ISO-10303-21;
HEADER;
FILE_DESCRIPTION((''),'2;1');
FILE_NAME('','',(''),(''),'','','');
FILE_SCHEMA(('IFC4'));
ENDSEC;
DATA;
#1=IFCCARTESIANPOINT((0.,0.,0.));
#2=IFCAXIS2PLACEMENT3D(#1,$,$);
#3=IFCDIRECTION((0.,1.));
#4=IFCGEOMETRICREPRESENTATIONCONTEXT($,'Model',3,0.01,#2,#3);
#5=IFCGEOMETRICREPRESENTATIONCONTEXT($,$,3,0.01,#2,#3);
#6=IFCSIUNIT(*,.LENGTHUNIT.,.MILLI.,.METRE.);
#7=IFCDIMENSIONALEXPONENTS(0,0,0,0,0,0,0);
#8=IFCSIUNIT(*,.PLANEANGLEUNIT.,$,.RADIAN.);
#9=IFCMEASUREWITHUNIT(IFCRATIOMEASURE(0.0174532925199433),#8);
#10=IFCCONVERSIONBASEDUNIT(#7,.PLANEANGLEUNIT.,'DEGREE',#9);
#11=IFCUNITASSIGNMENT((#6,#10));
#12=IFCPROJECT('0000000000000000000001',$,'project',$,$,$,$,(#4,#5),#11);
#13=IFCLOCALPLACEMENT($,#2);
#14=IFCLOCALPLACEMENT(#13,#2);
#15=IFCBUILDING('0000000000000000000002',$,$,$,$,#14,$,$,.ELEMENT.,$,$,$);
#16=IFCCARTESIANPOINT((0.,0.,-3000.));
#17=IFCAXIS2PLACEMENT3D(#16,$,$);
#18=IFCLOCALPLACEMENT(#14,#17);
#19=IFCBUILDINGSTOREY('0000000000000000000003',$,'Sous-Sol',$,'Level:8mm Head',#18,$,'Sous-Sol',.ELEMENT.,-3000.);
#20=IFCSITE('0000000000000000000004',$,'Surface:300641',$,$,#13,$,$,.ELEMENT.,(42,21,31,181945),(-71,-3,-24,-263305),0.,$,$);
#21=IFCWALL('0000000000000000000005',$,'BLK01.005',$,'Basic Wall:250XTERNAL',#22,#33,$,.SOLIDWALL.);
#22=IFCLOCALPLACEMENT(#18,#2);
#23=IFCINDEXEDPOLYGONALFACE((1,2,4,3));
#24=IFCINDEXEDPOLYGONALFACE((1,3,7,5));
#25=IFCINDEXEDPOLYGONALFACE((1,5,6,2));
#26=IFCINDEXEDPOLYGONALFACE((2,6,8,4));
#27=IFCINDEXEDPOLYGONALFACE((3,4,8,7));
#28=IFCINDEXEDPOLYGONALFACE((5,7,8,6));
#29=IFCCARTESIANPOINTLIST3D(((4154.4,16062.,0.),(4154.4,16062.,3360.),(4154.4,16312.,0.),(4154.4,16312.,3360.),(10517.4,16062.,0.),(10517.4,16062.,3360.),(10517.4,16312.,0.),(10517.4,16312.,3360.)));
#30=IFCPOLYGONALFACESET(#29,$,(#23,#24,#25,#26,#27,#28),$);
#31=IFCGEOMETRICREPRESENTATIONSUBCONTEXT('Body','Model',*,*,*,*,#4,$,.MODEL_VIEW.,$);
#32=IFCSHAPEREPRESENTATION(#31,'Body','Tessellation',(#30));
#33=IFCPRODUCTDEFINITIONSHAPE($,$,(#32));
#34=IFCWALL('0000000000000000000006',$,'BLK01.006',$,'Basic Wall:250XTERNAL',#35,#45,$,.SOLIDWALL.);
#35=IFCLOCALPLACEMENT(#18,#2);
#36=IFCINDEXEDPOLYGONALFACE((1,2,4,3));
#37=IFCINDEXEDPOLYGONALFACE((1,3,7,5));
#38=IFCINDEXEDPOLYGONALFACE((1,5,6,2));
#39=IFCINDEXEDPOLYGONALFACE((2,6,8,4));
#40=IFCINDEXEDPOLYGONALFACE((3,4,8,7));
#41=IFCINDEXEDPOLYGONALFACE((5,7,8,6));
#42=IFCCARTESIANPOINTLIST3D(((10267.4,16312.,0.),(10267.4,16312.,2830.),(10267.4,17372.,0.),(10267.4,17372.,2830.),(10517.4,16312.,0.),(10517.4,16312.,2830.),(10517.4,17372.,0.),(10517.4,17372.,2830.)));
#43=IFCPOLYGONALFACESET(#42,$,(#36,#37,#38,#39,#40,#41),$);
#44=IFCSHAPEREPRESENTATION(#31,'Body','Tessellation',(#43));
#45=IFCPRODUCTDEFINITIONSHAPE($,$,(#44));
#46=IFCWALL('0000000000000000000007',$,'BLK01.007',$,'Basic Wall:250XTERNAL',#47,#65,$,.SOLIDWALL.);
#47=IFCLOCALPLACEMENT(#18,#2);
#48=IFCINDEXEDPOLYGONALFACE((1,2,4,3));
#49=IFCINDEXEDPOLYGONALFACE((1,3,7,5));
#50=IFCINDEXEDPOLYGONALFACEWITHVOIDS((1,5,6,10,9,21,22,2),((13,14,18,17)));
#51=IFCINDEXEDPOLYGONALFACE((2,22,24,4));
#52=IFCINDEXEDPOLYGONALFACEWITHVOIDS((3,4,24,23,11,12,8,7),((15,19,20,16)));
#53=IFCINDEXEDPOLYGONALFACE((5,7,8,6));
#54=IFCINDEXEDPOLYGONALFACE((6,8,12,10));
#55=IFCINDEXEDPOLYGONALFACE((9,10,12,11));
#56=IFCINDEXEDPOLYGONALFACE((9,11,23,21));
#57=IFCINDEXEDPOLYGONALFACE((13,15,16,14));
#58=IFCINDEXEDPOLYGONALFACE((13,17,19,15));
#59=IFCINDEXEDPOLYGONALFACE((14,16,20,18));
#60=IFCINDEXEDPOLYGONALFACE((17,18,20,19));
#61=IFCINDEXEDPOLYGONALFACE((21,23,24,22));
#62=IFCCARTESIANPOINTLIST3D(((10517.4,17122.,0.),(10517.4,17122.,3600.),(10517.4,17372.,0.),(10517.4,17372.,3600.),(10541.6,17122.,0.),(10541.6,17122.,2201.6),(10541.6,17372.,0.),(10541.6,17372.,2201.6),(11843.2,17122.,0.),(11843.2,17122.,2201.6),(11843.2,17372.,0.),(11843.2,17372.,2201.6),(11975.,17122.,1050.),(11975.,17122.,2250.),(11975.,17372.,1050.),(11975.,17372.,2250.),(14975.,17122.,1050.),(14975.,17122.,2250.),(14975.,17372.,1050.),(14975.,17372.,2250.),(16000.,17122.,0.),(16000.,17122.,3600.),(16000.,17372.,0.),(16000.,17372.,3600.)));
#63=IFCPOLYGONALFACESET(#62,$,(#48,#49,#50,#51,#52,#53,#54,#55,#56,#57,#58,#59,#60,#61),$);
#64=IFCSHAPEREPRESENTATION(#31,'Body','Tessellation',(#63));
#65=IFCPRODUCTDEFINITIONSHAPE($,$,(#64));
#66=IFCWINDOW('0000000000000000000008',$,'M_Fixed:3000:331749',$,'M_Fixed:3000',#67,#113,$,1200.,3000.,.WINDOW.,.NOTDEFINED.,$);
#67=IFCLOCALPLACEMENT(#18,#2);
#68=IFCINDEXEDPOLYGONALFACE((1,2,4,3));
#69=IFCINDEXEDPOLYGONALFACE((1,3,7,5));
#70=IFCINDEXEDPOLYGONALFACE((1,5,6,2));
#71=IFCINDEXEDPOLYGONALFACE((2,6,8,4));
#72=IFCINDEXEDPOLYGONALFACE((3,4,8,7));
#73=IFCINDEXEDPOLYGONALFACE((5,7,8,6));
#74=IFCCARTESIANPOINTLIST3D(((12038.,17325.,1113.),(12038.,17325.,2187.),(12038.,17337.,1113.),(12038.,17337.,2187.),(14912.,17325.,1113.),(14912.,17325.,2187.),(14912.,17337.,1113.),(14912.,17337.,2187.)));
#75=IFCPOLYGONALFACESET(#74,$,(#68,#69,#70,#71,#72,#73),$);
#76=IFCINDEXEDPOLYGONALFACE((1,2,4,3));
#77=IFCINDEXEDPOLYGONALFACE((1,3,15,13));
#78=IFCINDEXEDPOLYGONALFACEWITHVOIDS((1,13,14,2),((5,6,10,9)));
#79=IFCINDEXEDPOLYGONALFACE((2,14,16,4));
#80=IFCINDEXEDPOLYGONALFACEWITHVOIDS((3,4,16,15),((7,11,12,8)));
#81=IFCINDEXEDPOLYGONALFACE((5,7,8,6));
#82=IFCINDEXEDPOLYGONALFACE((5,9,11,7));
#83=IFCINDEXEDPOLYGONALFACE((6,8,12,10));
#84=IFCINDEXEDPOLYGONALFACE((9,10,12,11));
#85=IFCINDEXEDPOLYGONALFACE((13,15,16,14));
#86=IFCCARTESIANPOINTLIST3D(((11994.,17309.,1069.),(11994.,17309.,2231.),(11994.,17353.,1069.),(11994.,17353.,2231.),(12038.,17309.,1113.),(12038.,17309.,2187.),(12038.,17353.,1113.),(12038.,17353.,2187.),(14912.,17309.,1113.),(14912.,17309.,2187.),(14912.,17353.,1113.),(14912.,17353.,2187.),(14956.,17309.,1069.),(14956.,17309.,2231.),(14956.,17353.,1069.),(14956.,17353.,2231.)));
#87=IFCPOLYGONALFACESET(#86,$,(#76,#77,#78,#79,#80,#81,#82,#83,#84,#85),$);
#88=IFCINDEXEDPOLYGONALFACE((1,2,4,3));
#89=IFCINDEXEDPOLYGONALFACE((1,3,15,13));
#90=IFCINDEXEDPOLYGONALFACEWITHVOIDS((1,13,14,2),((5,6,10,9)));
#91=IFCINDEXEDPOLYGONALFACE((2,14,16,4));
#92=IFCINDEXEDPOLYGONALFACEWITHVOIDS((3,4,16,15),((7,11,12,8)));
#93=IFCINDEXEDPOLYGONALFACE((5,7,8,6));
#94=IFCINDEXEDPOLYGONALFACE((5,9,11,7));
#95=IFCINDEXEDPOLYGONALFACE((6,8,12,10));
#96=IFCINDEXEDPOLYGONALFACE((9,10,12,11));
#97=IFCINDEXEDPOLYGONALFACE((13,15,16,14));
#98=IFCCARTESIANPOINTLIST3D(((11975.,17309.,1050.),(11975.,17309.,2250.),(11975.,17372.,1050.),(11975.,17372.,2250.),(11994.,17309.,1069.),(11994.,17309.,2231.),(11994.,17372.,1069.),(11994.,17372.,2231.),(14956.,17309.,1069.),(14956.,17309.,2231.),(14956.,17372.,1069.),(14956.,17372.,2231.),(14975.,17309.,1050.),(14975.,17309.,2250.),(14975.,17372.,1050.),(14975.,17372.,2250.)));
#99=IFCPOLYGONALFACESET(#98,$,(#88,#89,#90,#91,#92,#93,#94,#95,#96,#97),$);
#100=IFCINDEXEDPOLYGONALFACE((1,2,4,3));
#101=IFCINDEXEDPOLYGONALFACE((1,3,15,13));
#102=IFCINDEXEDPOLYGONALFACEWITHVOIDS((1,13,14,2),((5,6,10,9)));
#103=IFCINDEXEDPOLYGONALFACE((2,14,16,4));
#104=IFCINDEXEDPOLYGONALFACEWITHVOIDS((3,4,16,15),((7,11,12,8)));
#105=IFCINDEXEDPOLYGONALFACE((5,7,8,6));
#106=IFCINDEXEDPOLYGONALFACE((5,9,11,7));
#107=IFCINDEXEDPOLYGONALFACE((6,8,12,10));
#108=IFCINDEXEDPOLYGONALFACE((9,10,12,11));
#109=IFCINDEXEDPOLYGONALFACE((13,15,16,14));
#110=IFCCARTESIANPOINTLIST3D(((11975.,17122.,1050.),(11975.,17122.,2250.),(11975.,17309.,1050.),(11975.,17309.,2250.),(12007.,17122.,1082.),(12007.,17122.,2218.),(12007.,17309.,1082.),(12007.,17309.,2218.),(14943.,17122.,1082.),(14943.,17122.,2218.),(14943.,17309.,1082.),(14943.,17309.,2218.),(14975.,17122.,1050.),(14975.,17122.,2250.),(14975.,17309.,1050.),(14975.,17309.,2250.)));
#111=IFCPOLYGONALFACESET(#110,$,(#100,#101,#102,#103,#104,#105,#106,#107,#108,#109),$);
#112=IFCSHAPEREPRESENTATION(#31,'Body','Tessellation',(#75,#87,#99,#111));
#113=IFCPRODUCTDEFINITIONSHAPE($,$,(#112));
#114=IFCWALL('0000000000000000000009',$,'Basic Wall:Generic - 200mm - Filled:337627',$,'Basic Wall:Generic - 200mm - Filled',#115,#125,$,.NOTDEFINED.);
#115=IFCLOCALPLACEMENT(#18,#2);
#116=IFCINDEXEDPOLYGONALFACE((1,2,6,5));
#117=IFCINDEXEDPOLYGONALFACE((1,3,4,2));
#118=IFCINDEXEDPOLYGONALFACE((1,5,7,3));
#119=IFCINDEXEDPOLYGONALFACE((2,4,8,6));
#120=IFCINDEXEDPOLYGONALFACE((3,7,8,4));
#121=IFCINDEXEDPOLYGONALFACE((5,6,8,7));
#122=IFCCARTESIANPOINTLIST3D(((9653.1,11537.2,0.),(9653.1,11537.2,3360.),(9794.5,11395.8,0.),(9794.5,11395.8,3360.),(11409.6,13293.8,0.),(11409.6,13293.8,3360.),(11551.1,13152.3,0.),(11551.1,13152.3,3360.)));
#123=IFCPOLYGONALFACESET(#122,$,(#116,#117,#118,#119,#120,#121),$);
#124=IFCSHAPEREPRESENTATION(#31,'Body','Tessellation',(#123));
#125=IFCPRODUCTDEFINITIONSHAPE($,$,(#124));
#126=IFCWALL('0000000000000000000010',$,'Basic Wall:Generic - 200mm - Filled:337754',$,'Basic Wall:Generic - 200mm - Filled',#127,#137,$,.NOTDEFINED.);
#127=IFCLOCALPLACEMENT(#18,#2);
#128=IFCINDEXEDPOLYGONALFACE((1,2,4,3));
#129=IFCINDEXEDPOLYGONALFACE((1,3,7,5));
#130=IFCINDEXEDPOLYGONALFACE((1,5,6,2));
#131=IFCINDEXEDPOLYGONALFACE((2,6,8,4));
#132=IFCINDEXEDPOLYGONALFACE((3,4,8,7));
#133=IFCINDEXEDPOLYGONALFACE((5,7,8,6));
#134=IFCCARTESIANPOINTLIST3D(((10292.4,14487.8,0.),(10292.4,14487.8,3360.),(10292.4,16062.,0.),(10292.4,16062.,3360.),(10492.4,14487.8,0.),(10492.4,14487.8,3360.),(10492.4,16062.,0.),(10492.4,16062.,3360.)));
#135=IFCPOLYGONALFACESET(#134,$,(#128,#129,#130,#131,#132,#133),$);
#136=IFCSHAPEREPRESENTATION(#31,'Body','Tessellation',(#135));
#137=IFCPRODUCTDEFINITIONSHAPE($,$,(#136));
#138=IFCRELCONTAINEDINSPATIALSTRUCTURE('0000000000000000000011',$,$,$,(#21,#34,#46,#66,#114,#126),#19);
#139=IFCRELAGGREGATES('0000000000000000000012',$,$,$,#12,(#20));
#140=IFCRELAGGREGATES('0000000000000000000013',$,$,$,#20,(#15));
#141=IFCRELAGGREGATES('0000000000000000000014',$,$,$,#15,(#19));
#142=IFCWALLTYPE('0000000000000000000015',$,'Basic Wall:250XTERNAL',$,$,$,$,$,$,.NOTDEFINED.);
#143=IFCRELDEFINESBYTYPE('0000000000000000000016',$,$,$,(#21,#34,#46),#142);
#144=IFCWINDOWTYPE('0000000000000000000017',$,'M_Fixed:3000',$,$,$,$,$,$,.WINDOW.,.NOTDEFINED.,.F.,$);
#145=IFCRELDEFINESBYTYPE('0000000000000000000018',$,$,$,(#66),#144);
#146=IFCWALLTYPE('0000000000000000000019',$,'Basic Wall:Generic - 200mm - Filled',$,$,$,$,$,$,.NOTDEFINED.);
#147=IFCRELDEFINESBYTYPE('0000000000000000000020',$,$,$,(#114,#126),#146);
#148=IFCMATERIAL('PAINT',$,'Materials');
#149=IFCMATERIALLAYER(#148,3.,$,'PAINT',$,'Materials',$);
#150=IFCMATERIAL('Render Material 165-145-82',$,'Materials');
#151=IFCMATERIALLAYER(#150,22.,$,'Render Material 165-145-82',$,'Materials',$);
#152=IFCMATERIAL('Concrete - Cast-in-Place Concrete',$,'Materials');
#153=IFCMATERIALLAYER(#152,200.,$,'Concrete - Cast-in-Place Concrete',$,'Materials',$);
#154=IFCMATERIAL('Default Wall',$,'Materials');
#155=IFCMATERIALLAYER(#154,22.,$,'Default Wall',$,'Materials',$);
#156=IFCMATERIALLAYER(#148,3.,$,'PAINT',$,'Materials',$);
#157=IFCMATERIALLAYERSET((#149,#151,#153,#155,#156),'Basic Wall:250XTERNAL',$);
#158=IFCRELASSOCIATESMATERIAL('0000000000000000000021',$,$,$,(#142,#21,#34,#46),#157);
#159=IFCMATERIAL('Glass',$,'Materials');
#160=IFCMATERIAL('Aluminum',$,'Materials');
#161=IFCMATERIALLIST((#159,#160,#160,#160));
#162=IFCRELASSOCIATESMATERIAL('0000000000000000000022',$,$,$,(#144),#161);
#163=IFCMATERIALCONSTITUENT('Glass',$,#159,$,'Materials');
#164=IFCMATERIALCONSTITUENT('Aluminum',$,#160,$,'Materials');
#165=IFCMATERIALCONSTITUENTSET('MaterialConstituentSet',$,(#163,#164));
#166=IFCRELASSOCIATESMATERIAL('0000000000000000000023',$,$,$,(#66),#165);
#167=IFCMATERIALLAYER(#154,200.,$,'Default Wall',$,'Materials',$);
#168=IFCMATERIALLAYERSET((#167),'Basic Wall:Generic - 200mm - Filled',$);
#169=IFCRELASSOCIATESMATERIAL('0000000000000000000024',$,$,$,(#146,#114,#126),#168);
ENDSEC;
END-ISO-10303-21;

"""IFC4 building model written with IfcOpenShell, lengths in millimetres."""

from ifc_helpers import new_model, entity, si_unit, converted_unit, direction, frame, frame_2d, origin, place, context, subcontext, project, spatial, polyline, rectangle, outline, extrude, clip, bounded_halfspace, source, transform, mapped, material, material_list, layer, layer_set, layer_usage, constituent, constituent_set, type_object, type_shapes, element, fill, save


model = new_model("IFC4")

# Units and contexts
model_context = context("Model", 3, precision=0.01, world=origin(), true_north=direction((0.0, 1.0)))
context_of_model = context(None, 3, precision=0.01, world=origin(), true_north=direction((0.0, 1.0)))
body_context = subcontext(model_context, "Body", "Model", "MODEL_VIEW")
ifc_project = project(units=[si_unit("LENGTHUNIT", "METRE", prefix="MILLI"), converted_unit("PLANEANGLEUNIT", "DEGREE", entity("IfcRatioMeasure", 0.0174532925199433), si_unit("PLANEANGLEUNIT", "RADIAN"), dimensions=[0, 0, 0, 0, 0, 0, 0])], contexts=[model_context, context_of_model])

# Site, building, storey
site_placement = place(None, origin())
site = spatial("IfcSite", under=ifc_project, at=site_placement, Name="Surface:300641", CompositionType="ELEMENT", RefLatitude=(42, 21, 31, 181945), RefLongitude=(-71, -3, -24, -263305), RefElevation=0.0)
building_placement = place(site_placement, origin())
building = spatial("IfcBuilding", under=site, at=building_placement, CompositionType="ELEMENT")
storey_placement = place(building_placement, frame((0.0, 0.0, -3000.0)))
storey = spatial("IfcBuildingStorey", under=building, at=storey_placement, Name="Sous-Sol", ObjectType="Level:8mm Head", LongName="Sous-Sol", CompositionType="ELEMENT", Elevation=-3000.0)

# Walls
ifc_material_1 = material(Name="PAINT", Category="Materials")
ifc_layer_1 = layer(ifc_material_1, 3.0, Name="PAINT", Category="Materials")
ifc_material_2 = material(Name="Render Material 165-145-82", Category="Materials")
ifc_layer_2 = layer(ifc_material_2, 22.0, Name="Render Material 165-145-82", Category="Materials")
ifc_material_3 = material(Name="Concrete - Cast-in-Place Concrete", Category="Materials")
ifc_layer_3 = layer(ifc_material_3, 200.0, Name="Concrete - Cast-in-Place Concrete", Category="Materials")
ifc_material_4 = material(Name="Default Wall", Category="Materials")
ifc_layer_4 = layer(ifc_material_4, 22.0, Name="Default Wall", Category="Materials")
ifc_layer_5 = layer(ifc_material_1, 3.0, Name="PAINT", Category="Materials")
ifc_layer_set_1 = layer_set([ifc_layer_1, ifc_layer_2, ifc_layer_3, ifc_layer_4, ifc_layer_5], Name="Basic Wall:250XTERNAL")
ifc_layer_usage_1 = layer_usage(ifc_layer_set_1, "AXIS2", "NEGATIVE", 125.0)
wall_type_1 = type_object("IfcWallType", Name="Basic Wall:250XTERNAL", PredefinedType="NOTDEFINED", material=ifc_layer_set_1)
wall_1_placement = place(storey_placement, frame((4154.4, 16187.0, 0.0)))
element("IfcWall", 1, at=wall_1_placement, inside=storey, type_object=wall_type_1, material=ifc_layer_usage_1, Name="BLK01.005", ObjectType="Basic Wall:250XTERNAL", PredefinedType="SOLIDWALL", context=body_context, shape_type="Clipping", body=[
    clip(extrude(rectangle(XDim=6362.9, YDim=250.0, at=frame_2d((3181.5, 0.0), x_axis=(-1.0, 0.0))), origin(), (0.0, 0.0, 1.0), 3360.0), bounded_halfspace(frame((0.0, -125.0, 3360.0), z_axis=(0.0, 0.0, -1.0), x_axis=(0.0, -1.0, 0.0)), True, frame((0.0, -125.0, 3360.0)), polyline([(0.0, 0.0), (6137.9, 0.0), (6337.9, 0.0), (6362.9, 0.0), (6362.9, 250.0), (6112.9, 250.0), (0.0, 250.0), (0.0, 0.0)]))),
])
ifc_layer_usage_2 = layer_usage(ifc_layer_set_1, "AXIS2", "NEGATIVE", 125.0)
wall_2_placement = place(storey_placement, frame((10392.4, 16312.0, 0.0), z_axis=(0.0, 0.0, 1.0), x_axis=(0.0, 1.0, 0.0)))
element("IfcWall", 2, at=wall_2_placement, inside=storey, type_object=wall_type_1, material=ifc_layer_usage_2, Name="BLK01.006", ObjectType="Basic Wall:250XTERNAL", PredefinedType="SOLIDWALL", context=body_context, shape_type="SweptSolid", body=[
    extrude(rectangle(XDim=1060.0, YDim=250.0, at=frame_2d((530.0, 0.0), x_axis=(-1.0, 0.0))), origin(), (0.0, 0.0, 1.0), 2830.0),
])

# Wall, openings, window
ifc_layer_usage_3 = layer_usage(ifc_layer_set_1, "AXIS2", "NEGATIVE", 125.0)
wall_3_placement = place(storey_placement, frame((10517.4, 17247.0, 0.0)))
wall_3 = element("IfcWall", 3, at=wall_3_placement, inside=storey, type_object=wall_type_1, material=ifc_layer_usage_3, Name="BLK01.007", ObjectType="Basic Wall:250XTERNAL", PredefinedType="SOLIDWALL", context=body_context, shape_type="SweptSolid", body=[
    extrude(rectangle(XDim=5482.6, YDim=250.0, at=frame_2d((2741.3, 0.0), x_axis=(-1.0, 0.0))), origin(), (0.0, 0.0, 1.0), 3600.0),
])
opening_1_placement = place(wall_3_placement, frame((24.2, -125.0, 0.0)))
element("IfcOpeningElement", 4, at=opening_1_placement, cuts=wall_3, ObjectType="Opening", PredefinedType="OPENING", context=body_context, shape_type="SweptSolid", body=[
    extrude(rectangle(XDim=2201.6, YDim=1301.6, at=frame_2d((1100.8, 650.8), x_axis=(1.0, 0.0))), frame((0.0, 0.0, 0.0), z_axis=(0.0, 1.0, 0.0), x_axis=(0.0, 0.0, 1.0)), (0.0, 0.0, 1.0), 250.0),
])
opening_2_placement = place(wall_3_placement, frame((1457.6, -125.0, 1050.0)))
opening_2 = element("IfcOpeningElement", 5, at=opening_2_placement, cuts=wall_3, ObjectType="Opening", PredefinedType="OPENING", context=body_context, shape_type="SweptSolid", body=[
    extrude(rectangle(XDim=1200.0, YDim=3000.0, at=frame_2d((600.0, 1500.0), x_axis=(1.0, 0.0))), frame((0.0, 0.0, 0.0), z_axis=(0.0, 1.0, 0.0), x_axis=(0.0, 0.0, 1.0)), (0.0, 0.0, 1.0), 250.0),
])
ifc_material_5 = material(Name="Glass", Category="Materials")
ifc_constituent_1 = constituent(ifc_material_5, Name="Glass", Category="Materials")
ifc_material_6 = material(Name="Aluminum", Category="Materials")
ifc_constituent_2 = constituent(ifc_material_6, Name="Aluminum", Category="Materials")
ifc_constituent_set_1 = constituent_set(constituents=[ifc_constituent_1, ifc_constituent_2], Name="MaterialConstituentSet")
ifc_material_list_1 = material_list([ifc_material_5, ifc_material_6, ifc_material_6, ifc_material_6])
window_type = type_object("IfcWindowType", Name="M_Fixed:3000", ParameterTakesPrecedence=False, PartitioningType="NOTDEFINED", PredefinedType="WINDOW", material=ifc_material_list_1)
shared_shape_1 = source(origin(), body_context, "Body", "SweptSolid", [
    extrude(rectangle(XDim=12.0, YDim=2874.0, at=frame_2d((0.0, 0.0), x_axis=(1.0, 0.0))), frame((1500.0, 209.0, 63.0), z_axis=(0.0, 0.0, 1.0), x_axis=(0.0, -1.0, 0.0)), (0.0, 0.0, 1.0), 1074.0),
    extrude(outline(polyline([(-1481.0, -581.0), (1481.0, -581.0), (1481.0, 581.0), (-1481.0, 581.0), (-1481.0, -581.0)]), holes=[polyline([(-1437.0, -537.0), (-1437.0, 537.0), (1437.0, 537.0), (1437.0, -537.0), (-1437.0, -537.0)])]), frame((1500.0, 187.0, 600.0), z_axis=(0.0, 1.0, 0.0), x_axis=(1.0, 0.0, 0.0)), (0.0, 0.0, 1.0), 44.0),
    extrude(outline(polyline([(-1500.0, -600.0), (1500.0, -600.0), (1500.0, 600.0), (-1500.0, 600.0), (-1500.0, -600.0)]), holes=[polyline([(-1481.0, -581.0), (-1481.0, 581.0), (1481.0, 581.0), (1481.0, -581.0), (-1481.0, -581.0)])]), frame((1500.0, 187.0, 600.0), z_axis=(0.0, 1.0, 0.0), x_axis=(1.0, 0.0, 0.0)), (0.0, 0.0, 1.0), 63.0),
    extrude(outline(polyline([(-1500.0, -600.0), (1500.0, -600.0), (1500.0, 600.0), (-1500.0, 600.0), (-1500.0, -600.0)]), holes=[polyline([(-1468.0, -568.0), (-1468.0, 568.0), (1468.0, 568.0), (1468.0, -568.0), (-1468.0, -568.0)])]), frame((1500.0, 0.0, 600.0), z_axis=(0.0, 1.0, 0.0), x_axis=(1.0, 0.0, 0.0)), (0.0, 0.0, 1.0), 187.0),
])
type_shapes(window_type, [shared_shape_1])
window_placement = place(opening_2_placement, origin())
window = element("IfcWindow", 6, at=window_placement, inside=storey, type_object=window_type, material=ifc_constituent_set_1, Name="M_Fixed:3000:331749", ObjectType="M_Fixed:3000", OverallHeight=1200.0, OverallWidth=3000.0, PartitioningType="NOTDEFINED", PredefinedType="WINDOW", context=body_context, shape_type="MappedRepresentation", body=[
    mapped(shared_shape_1, transform((0.0, 0.0, 0.0), scale=1.0)),
])
fill(opening_2, window)

# Shared definitions
ifc_layer_6 = layer(ifc_material_4, 200.0, Name="Default Wall", Category="Materials")
ifc_layer_set_2 = layer_set([ifc_layer_6], Name="Basic Wall:Generic - 200mm - Filled")
wall_type_2 = type_object("IfcWallType", Name="Basic Wall:Generic - 200mm - Filled", PredefinedType="NOTDEFINED", material=ifc_layer_set_2)

# Walls
ifc_layer_usage_4 = layer_usage(ifc_layer_set_2, "AXIS2", "NEGATIVE", 100.0)
wall_4_placement = place(storey_placement, frame((11480.3, 13223.0, 0.0), z_axis=(0.0, 0.0, 1.0), x_axis=(-0.707107, -0.707107, 0.0)))
element("IfcWall", 7, at=wall_4_placement, inside=storey, type_object=wall_type_2, material=ifc_layer_usage_4, Name="Basic Wall:Generic - 200mm - Filled:337627", ObjectType="Basic Wall:Generic - 200mm - Filled", PredefinedType="NOTDEFINED", context=body_context, shape_type="Clipping", body=[
    clip(extrude(rectangle(XDim=2484.1, YDim=200.0, at=frame_2d((1242.1, 0.0), x_axis=(-1.0, 0.0))), origin(), (0.0, 0.0, 1.0), 3360.0), bounded_halfspace(frame((0.0, -100.0, 3360.0), z_axis=(0.0, 0.0, -1.0), x_axis=(0.707107, 0.707107, 0.0)), True, frame((0.0, -100.0, 3360.0)), polyline([(0.0, 0.0), (2484.1, 0.0), (2484.1, 200.0), (0.0, 200.0), (0.0, 0.0)]))),
])
ifc_layer_usage_5 = layer_usage(ifc_layer_set_2, "AXIS2", "NEGATIVE", 100.0)
wall_5_placement = place(storey_placement, frame((10392.4, 16062.0, 0.0), z_axis=(0.0, 0.0, 1.0), x_axis=(0.0, -1.0, 0.0)))
element("IfcWall", 8, at=wall_5_placement, inside=storey, type_object=wall_type_2, material=ifc_layer_usage_5, Name="Basic Wall:Generic - 200mm - Filled:337754", ObjectType="Basic Wall:Generic - 200mm - Filled", PredefinedType="NOTDEFINED", context=body_context, shape_type="Clipping", body=[
    clip(extrude(rectangle(XDim=1574.2, YDim=200.0, at=frame_2d((787.1, 0.0), x_axis=(-1.0, 0.0))), origin(), (0.0, 0.0, 1.0), 3360.0), bounded_halfspace(frame((0.0, -100.0, 3360.0), z_axis=(0.0, 0.0, -1.0), x_axis=(1.0, 0.0, 0.0)), True, frame((0.0, -100.0, 3360.0)), polyline([(0.0, 0.0), (1574.2, 0.0), (1574.2, 200.0), (0.0, 200.0), (0.0, 0.0)]))),
])

save(model, "model.ifc")
